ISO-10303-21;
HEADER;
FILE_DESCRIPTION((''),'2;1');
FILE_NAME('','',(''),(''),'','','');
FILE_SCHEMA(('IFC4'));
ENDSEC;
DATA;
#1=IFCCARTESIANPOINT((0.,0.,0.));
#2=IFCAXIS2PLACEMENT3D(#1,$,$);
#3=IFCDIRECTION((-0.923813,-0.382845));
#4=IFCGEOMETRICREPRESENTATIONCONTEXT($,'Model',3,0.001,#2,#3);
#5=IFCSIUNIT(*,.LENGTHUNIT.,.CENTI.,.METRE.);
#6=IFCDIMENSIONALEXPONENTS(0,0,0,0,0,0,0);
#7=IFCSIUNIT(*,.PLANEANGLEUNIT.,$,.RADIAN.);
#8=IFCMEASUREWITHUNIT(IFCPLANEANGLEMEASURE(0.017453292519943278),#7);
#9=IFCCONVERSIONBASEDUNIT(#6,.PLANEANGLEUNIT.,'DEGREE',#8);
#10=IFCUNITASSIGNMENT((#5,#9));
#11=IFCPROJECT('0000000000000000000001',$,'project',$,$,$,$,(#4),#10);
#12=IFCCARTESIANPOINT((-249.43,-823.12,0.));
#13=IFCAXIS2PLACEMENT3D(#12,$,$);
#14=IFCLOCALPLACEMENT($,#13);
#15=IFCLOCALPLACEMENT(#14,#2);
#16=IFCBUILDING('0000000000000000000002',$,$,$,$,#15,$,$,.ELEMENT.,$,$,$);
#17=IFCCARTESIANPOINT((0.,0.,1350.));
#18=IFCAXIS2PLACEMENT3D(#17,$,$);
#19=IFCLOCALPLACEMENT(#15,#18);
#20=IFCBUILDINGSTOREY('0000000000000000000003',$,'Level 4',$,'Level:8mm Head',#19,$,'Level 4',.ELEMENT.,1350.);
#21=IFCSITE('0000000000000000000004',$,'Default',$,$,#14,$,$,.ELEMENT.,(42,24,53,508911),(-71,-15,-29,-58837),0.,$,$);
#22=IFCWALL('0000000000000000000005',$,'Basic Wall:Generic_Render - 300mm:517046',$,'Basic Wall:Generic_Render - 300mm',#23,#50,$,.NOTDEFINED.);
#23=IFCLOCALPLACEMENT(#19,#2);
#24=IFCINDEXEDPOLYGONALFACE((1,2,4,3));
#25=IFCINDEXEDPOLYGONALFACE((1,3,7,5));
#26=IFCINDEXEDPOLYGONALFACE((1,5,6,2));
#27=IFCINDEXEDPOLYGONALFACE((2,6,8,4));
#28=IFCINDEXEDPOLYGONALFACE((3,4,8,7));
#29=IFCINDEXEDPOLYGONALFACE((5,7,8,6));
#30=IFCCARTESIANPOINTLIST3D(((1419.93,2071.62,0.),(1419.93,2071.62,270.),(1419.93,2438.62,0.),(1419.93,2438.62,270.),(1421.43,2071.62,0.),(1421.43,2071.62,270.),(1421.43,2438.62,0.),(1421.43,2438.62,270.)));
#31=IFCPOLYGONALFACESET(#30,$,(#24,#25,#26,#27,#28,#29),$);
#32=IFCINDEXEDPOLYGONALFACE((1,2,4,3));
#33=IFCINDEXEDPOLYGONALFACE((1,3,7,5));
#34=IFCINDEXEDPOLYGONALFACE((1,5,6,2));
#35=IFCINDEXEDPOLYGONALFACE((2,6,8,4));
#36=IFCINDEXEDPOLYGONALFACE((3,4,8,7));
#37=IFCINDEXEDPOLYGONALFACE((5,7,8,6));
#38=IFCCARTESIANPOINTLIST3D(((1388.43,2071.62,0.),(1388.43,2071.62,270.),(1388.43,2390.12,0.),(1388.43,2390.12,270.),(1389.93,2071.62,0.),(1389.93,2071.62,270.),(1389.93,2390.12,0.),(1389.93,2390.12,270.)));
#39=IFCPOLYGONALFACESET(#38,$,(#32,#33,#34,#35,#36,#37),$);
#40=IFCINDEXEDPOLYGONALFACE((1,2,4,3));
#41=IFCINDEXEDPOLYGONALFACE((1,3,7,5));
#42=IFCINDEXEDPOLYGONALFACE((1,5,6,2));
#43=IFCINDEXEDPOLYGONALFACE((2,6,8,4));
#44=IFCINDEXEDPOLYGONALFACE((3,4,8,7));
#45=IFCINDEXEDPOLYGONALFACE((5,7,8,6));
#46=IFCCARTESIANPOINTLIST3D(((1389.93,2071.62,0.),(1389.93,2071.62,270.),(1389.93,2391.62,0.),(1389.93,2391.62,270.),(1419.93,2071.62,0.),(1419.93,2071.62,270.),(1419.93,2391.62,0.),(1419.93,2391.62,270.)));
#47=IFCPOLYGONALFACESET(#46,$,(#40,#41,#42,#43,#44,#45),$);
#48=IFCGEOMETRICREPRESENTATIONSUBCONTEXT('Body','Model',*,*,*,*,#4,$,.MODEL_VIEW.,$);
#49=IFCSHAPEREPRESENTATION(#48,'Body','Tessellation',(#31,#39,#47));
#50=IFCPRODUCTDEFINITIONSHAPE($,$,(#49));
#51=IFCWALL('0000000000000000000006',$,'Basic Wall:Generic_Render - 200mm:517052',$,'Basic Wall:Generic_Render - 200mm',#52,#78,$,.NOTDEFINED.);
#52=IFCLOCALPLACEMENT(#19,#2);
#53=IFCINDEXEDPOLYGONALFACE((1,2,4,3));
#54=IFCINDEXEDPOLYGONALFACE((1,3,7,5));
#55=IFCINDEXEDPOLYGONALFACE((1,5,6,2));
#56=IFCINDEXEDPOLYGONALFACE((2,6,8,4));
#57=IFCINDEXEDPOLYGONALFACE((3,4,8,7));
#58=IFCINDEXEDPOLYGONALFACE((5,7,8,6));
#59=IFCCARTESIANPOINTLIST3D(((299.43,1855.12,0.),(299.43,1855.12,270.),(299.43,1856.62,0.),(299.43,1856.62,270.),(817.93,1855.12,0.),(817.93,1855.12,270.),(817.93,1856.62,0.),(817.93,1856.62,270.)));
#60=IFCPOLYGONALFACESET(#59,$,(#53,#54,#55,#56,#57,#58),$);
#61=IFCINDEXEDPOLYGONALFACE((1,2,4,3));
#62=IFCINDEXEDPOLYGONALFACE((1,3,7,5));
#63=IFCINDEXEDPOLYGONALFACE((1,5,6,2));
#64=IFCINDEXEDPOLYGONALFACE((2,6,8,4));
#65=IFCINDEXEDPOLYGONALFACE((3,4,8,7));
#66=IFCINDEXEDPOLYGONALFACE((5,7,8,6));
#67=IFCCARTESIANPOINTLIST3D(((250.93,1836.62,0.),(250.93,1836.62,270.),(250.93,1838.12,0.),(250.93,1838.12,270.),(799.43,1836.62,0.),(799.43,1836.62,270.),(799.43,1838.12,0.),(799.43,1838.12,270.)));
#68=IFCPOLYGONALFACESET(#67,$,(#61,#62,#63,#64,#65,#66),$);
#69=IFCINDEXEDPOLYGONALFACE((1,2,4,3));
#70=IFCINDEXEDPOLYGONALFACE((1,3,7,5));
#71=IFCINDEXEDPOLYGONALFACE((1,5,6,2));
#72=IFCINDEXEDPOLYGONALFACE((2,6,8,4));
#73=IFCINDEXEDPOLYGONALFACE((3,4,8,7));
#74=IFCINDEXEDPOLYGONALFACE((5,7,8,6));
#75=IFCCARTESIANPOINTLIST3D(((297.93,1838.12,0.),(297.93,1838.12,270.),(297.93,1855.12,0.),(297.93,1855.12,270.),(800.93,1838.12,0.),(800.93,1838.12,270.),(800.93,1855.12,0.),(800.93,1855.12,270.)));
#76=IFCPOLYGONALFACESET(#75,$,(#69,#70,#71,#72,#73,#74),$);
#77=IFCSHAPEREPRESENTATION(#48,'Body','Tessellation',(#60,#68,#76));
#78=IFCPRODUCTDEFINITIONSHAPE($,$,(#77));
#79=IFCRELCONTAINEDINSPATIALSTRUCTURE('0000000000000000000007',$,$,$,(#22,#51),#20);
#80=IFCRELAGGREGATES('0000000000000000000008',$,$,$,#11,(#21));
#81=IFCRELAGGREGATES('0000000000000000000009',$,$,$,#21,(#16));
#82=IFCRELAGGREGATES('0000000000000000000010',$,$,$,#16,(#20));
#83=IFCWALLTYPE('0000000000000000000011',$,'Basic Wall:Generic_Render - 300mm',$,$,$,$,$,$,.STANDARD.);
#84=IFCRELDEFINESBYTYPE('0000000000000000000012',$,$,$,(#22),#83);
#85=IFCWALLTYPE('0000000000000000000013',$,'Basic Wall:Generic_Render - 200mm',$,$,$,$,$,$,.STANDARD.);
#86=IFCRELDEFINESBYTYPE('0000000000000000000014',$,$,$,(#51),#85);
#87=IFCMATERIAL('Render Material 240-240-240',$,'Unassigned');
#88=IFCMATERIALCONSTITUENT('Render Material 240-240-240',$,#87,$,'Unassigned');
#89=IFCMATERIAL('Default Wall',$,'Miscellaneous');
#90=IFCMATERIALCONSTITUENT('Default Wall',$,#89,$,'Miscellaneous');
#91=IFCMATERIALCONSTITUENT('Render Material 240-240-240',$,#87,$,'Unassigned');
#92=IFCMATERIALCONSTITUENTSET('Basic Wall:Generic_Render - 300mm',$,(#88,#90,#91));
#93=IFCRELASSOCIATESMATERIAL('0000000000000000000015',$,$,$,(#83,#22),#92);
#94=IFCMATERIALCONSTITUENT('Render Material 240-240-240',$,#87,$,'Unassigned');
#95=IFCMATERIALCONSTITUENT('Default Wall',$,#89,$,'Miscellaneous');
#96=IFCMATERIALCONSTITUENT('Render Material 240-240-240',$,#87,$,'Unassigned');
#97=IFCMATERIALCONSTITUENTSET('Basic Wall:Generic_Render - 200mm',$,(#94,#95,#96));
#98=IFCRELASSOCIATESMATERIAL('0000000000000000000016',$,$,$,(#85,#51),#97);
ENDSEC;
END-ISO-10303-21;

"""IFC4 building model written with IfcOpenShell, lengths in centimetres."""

from ifc_helpers import new_model, entity, si_unit, converted_unit, direction, frame, origin, place, context, subcontext, project, spatial, indexed_curve, outline, extrude, material, constituent, constituent_set, type_object, element, save


model = new_model("IFC4")

# Units and contexts
model_context = context("Model", 3, precision=0.001, world=origin(), true_north=direction((-0.923813, -0.382845)))
body_context = subcontext(model_context, "Body", "Model", "MODEL_VIEW")
ifc_project = project(units=[si_unit("LENGTHUNIT", "METRE", prefix="CENTI"), converted_unit("PLANEANGLEUNIT", "DEGREE", entity("IfcPlaneAngleMeasure", 0.017453292519943278), si_unit("PLANEANGLEUNIT", "RADIAN"), dimensions=[0, 0, 0, 0, 0, 0, 0])], contexts=[model_context])

# Site, building, storey
site_placement = place(None, frame((-249.43, -823.12, 0.0)))
site = spatial("IfcSite", under=ifc_project, at=site_placement, Name="Default", CompositionType="ELEMENT", RefLatitude=(42, 24, 53, 508911), RefLongitude=(-71, -15, -29, -58837), RefElevation=0.0)
building_placement = place(site_placement, origin())
building = spatial("IfcBuilding", under=site, at=building_placement, CompositionType="ELEMENT")
storey_placement = place(building_placement, frame((0.0, 0.0, 1350.0)))
storey = spatial("IfcBuildingStorey", under=building, at=storey_placement, Name="Level 4", ObjectType="Level:8mm Head", LongName="Level 4", CompositionType="ELEMENT", Elevation=1350.0)

# Wall
ifc_material_1 = material(Name="Render Material 240-240-240", Category="Unassigned")
ifc_constituent_1 = constituent(ifc_material_1, Name="Render Material 240-240-240", Category="Unassigned")
ifc_material_2 = material(Name="Default Wall", Category="Miscellaneous")
ifc_constituent_2 = constituent(ifc_material_2, Name="Default Wall", Category="Miscellaneous")
ifc_constituent_3 = constituent(ifc_material_1, Name="Render Material 240-240-240", Category="Unassigned")
ifc_constituent_set_1 = constituent_set(constituents=[ifc_constituent_1, ifc_constituent_2, ifc_constituent_3], Name="Basic Wall:Generic_Render - 300mm")
wall_type_1 = type_object("IfcWallType", Name="Basic Wall:Generic_Render - 300mm", PredefinedType="STANDARD", material=ifc_constituent_set_1)
wall_1_placement = place(storey_placement, frame((1404.93, 2071.62, 0.0), z_axis=(0.0, 0.0, 1.0), x_axis=(0.0, 1.0, 0.0)))
element("IfcWall", 1, at=wall_1_placement, inside=storey, type_object=wall_type_1, material=ifc_constituent_set_1, Name="Basic Wall:Generic_Render - 300mm:517046", ObjectType="Basic Wall:Generic_Render - 300mm", PredefinedType="NOTDEFINED", context=body_context, shape_type="SweptSolid", body=[
    extrude(outline(indexed_curve([(-0.75, -183.5), (0.75, -183.5), (0.75, 183.5), (-0.75, 183.5), (-0.75, -183.5)], self_intersect=False)), frame((183.5, -15.75, 0.0), z_axis=(0.0, 0.0, 1.0), x_axis=(0.0, 1.0, 0.0)), (0.0, 0.0, 1.0), 270.0),
    extrude(outline(indexed_curve([(-0.75, -159.25), (0.75, -159.25), (0.75, 159.25), (-0.75, 159.25), (-0.75, -159.25)], self_intersect=False)), frame((159.25, 15.75, 0.0), z_axis=(0.0, 0.0, 1.0), x_axis=(0.0, -1.0, 0.0)), (0.0, 0.0, 1.0), 270.0),
    extrude(outline(indexed_curve([(-160.0, -15.0), (160.0, -15.0), (160.0, 15.0), (-160.0, 15.0), (-160.0, -15.0)], self_intersect=False)), frame((160.0, 0.0, 0.0)), (0.0, 0.0, 1.0), 270.0),
])

# Shared definitions
ifc_constituent_4 = constituent(ifc_material_1, Name="Render Material 240-240-240", Category="Unassigned")
ifc_constituent_5 = constituent(ifc_material_2, Name="Default Wall", Category="Miscellaneous")
ifc_constituent_6 = constituent(ifc_material_1, Name="Render Material 240-240-240", Category="Unassigned")
ifc_constituent_set_2 = constituent_set(constituents=[ifc_constituent_4, ifc_constituent_5, ifc_constituent_6], Name="Basic Wall:Generic_Render - 200mm")
wall_type_2 = type_object("IfcWallType", Name="Basic Wall:Generic_Render - 200mm", PredefinedType="STANDARD", material=ifc_constituent_set_2)

# Wall
wall_2_placement = place(storey_placement, frame((799.43, 1846.62, 0.0), z_axis=(0.0, 0.0, 1.0), x_axis=(-1.0, 0.0, 0.0)))
element("IfcWall", 2, at=wall_2_placement, inside=storey, type_object=wall_type_2, material=ifc_constituent_set_2, Name="Basic Wall:Generic_Render - 200mm:517052", ObjectType="Basic Wall:Generic_Render - 200mm", PredefinedType="NOTDEFINED", context=body_context, shape_type="SweptSolid", body=[
    extrude(outline(indexed_curve([(-0.75, -259.25), (0.75, -259.25), (0.75, 259.25), (-0.75, 259.25), (-0.75, -259.25)], self_intersect=False)), frame((240.75, -9.25, 0.0), z_axis=(0.0, 0.0, 1.0), x_axis=(0.0, 1.0, 0.0)), (0.0, 0.0, 1.0), 270.0),
    extrude(outline(indexed_curve([(-0.75, -274.25), (0.75, -274.25), (0.75, 274.25), (-0.75, 274.25), (-0.75, -274.25)], self_intersect=False)), frame((274.25, 9.25, 0.0), z_axis=(0.0, 0.0, 1.0), x_axis=(0.0, -1.0, 0.0)), (0.0, 0.0, 1.0), 270.0),
    extrude(outline(indexed_curve([(-251.5, -8.5), (251.5, -8.5), (251.5, 8.5), (-251.5, 8.5), (-251.5, -8.5)], self_intersect=False)), frame((250.0, 0.0, 0.0)), (0.0, 0.0, 1.0), 270.0),
])

save(model, "model.ifc")
